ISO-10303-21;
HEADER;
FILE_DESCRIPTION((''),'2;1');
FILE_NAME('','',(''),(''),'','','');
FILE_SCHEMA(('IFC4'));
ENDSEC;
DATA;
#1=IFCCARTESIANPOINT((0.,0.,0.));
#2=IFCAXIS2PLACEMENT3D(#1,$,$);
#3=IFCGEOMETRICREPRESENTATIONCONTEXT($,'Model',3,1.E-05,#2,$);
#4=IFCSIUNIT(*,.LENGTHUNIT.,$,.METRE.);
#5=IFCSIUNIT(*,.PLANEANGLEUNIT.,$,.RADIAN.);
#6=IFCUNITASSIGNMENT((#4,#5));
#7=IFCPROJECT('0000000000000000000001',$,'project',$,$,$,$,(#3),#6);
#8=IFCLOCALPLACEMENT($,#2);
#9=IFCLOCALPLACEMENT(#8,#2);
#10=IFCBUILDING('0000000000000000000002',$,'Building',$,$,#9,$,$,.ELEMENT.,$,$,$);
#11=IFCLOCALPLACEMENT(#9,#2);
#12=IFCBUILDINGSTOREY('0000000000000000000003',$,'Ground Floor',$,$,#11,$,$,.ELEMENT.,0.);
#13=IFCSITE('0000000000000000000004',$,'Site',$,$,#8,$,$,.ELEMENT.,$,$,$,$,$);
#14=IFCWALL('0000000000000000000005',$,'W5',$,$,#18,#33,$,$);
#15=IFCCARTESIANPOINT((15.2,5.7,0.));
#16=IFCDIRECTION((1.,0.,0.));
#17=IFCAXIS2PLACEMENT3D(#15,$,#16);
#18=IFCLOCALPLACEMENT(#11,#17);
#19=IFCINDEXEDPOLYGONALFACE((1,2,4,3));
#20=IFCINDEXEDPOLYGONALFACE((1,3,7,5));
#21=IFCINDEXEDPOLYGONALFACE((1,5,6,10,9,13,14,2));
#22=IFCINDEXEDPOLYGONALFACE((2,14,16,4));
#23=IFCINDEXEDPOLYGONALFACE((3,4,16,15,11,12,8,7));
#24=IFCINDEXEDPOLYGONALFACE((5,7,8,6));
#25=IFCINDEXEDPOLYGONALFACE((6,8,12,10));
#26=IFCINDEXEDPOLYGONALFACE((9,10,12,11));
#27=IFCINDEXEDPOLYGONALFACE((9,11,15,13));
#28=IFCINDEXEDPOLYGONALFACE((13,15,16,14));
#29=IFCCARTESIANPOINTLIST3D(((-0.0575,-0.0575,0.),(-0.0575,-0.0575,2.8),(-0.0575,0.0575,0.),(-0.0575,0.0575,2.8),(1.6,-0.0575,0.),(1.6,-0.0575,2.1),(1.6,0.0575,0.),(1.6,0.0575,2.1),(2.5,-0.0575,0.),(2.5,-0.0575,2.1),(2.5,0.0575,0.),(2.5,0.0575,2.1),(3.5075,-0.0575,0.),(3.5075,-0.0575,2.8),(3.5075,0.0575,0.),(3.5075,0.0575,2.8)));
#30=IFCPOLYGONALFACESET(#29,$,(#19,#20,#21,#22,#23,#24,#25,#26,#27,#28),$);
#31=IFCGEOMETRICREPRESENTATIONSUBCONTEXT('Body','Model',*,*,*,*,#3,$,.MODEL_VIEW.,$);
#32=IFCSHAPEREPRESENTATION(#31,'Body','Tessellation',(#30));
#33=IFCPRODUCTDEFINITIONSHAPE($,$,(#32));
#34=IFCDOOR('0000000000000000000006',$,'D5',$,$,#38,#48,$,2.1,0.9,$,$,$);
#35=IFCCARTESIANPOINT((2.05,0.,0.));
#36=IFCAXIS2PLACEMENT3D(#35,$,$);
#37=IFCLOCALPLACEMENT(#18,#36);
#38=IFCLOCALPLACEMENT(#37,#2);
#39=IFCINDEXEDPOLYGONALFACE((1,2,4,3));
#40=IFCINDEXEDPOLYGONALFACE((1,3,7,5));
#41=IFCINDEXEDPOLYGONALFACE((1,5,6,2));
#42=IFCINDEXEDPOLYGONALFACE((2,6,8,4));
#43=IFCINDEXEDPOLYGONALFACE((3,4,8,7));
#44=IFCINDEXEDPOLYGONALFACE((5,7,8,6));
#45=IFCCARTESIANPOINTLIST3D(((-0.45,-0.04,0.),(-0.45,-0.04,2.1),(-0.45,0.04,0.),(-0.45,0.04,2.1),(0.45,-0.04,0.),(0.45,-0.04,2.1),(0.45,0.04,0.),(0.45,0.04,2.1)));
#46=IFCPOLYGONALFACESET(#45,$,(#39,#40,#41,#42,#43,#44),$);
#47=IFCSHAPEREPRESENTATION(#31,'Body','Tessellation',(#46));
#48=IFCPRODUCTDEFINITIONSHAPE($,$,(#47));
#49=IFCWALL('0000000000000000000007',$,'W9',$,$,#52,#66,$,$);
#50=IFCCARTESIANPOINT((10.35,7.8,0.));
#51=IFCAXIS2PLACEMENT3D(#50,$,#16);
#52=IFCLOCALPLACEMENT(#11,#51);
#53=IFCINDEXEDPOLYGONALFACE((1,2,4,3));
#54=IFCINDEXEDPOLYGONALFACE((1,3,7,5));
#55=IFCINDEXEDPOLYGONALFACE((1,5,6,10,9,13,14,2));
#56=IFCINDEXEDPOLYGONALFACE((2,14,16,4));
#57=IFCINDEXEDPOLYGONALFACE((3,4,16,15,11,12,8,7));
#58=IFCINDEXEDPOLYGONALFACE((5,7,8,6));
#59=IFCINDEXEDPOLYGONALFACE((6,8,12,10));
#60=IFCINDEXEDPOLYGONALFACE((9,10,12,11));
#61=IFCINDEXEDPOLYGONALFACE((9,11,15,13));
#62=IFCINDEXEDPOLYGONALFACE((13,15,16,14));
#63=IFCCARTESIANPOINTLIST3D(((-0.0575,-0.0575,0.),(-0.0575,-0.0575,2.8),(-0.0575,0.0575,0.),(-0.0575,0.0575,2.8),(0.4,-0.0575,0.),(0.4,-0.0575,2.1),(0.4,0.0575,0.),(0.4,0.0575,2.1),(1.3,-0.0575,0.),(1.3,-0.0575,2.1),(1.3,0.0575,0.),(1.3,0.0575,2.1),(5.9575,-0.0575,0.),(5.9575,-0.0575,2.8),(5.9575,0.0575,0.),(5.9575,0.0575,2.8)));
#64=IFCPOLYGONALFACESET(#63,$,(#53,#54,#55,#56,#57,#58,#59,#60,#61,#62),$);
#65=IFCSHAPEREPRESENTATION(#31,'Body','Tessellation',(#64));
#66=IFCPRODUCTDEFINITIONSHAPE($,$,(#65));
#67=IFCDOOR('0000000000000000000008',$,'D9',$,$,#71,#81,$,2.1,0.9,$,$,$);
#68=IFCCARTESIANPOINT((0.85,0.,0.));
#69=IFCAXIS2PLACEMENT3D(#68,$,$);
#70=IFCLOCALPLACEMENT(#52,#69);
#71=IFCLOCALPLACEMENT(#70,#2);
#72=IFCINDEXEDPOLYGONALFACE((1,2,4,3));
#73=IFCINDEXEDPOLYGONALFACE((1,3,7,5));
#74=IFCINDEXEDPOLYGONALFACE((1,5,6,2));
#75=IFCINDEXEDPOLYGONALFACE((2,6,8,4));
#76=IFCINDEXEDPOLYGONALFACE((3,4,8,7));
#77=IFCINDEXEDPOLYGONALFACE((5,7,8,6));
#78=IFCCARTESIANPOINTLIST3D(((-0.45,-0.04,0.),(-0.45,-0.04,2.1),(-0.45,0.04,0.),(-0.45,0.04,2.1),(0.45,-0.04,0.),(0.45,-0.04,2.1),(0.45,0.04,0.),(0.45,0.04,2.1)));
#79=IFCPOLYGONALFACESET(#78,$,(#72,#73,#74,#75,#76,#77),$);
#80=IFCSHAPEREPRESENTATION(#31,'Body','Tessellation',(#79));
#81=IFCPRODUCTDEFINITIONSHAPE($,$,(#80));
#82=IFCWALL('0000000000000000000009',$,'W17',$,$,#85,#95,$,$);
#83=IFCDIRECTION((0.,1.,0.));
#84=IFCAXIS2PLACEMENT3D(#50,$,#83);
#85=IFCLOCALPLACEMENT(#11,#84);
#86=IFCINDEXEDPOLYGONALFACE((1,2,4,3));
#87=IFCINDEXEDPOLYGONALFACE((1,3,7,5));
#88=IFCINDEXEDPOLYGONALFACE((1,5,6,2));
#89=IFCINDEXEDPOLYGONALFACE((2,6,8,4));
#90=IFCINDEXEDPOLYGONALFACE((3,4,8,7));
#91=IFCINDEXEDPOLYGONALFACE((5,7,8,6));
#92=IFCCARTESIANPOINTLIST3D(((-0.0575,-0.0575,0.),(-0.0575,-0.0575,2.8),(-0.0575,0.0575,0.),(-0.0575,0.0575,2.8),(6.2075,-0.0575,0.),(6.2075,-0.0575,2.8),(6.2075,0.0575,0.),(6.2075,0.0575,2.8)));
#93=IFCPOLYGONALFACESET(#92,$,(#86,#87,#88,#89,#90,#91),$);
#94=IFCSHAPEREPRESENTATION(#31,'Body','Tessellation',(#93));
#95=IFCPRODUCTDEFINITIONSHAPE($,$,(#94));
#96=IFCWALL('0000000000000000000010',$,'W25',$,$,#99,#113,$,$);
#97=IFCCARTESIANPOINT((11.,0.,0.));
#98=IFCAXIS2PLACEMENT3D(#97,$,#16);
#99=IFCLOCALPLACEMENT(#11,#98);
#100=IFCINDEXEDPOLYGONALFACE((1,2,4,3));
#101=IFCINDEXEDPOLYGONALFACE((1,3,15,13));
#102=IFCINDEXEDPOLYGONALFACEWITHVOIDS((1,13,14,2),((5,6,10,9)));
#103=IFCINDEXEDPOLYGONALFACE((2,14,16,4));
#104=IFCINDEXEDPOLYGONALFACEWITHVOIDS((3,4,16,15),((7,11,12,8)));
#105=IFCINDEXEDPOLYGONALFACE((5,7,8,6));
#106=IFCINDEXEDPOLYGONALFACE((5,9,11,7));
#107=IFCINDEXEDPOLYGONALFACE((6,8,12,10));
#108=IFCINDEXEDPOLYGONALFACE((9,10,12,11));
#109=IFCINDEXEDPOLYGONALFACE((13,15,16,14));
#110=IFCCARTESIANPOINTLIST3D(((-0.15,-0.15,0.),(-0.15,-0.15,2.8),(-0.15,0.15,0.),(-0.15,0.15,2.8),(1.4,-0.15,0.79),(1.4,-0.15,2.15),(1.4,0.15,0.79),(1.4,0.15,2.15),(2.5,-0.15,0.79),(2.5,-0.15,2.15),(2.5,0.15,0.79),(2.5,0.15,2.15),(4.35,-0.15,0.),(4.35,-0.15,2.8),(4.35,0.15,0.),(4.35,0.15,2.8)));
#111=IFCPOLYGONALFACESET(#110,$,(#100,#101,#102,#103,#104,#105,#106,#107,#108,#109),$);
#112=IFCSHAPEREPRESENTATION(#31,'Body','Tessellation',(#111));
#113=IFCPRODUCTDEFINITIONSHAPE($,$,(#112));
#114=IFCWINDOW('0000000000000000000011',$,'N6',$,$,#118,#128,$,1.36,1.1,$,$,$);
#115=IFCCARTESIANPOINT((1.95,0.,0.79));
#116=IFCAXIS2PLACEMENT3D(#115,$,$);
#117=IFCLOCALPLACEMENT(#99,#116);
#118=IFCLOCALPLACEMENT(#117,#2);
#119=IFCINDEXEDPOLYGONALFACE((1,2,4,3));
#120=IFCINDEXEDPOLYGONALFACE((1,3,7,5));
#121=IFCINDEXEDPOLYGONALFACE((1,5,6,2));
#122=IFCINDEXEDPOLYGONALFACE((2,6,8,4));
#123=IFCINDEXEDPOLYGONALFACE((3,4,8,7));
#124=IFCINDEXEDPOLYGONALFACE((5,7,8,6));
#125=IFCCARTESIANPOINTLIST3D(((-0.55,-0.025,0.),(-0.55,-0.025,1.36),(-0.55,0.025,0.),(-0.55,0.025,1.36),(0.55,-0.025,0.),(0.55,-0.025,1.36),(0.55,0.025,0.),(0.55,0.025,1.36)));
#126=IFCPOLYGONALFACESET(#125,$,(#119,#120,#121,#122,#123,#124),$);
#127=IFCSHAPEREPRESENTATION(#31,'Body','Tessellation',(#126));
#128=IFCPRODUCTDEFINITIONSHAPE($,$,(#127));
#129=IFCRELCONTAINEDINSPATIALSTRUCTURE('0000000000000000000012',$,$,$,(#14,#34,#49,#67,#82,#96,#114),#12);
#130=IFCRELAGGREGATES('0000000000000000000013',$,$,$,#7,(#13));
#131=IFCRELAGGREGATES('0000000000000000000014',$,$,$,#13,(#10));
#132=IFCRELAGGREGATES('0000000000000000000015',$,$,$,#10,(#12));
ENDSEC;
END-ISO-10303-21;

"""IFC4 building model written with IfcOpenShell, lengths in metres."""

from ifc_helpers import new_model, si_unit, frame, frame_2d, origin, origin_2d, place, context, subcontext, project, spatial, rectangle, extrude, element, fill, save


model = new_model("IFC4")

# Units and contexts
model_context = context("Model", 3, precision=1e-05, world=origin())
body_context = subcontext(model_context, "Body", "Model", "MODEL_VIEW")
ifc_project = project(units=[si_unit("LENGTHUNIT", "METRE"), si_unit("PLANEANGLEUNIT", "RADIAN")], contexts=[model_context])

# Site, building, storey
site_placement = place(None, origin())
site = spatial("IfcSite", under=ifc_project, at=site_placement, Name="Site", CompositionType="ELEMENT")
building_placement = place(site_placement, origin())
building = spatial("IfcBuilding", under=site, at=building_placement, Name="Building", CompositionType="ELEMENT")
storey_placement = place(building_placement, origin())
storey = spatial("IfcBuildingStorey", under=building, at=storey_placement, Name="Ground Floor", CompositionType="ELEMENT", Elevation=0.0)

# Walls, openings, doors
wall_1_placement = place(storey_placement, frame((15.2, 5.7, 0.0), x_axis=(1.0, 0.0, 0.0)))
wall_1 = element("IfcWall", 1, at=wall_1_placement, inside=storey, Name="W5", context=body_context, shape_type="SweptSolid", body=[
    extrude(rectangle(XDim=3.565, YDim=0.115, at=frame_2d((1.725, 0.0))), origin(), (0.0, 0.0, 1.0), 2.8),
])
opening_1_placement = place(wall_1_placement, frame((2.05, 0.0, 0.0)))
opening_1 = element("IfcOpeningElement", 2, at=opening_1_placement, cuts=wall_1, context=body_context, shape_type="SweptSolid", body=[
    extrude(rectangle(XDim=0.9, YDim=0.215, at=origin_2d()), origin(), (0.0, 0.0, 1.0), 2.1),
])
door_1_placement = place(opening_1_placement, origin())
door_1 = element("IfcDoor", 3, at=door_1_placement, inside=storey, Name="D5", OverallHeight=2.1, OverallWidth=0.9, context=body_context, shape_type="SweptSolid", body=[
    extrude(rectangle(XDim=0.9, YDim=0.08, at=origin_2d()), origin(), (0.0, 0.0, 1.0), 2.1),
])
fill(opening_1, door_1)
wall_2_placement = place(storey_placement, frame((10.35, 7.8, 0.0), x_axis=(1.0, 0.0, 0.0)))
wall_2 = element("IfcWall", 4, at=wall_2_placement, inside=storey, Name="W9", context=body_context, shape_type="SweptSolid", body=[
    extrude(rectangle(XDim=6.015, YDim=0.115, at=frame_2d((2.95, 0.0))), origin(), (0.0, 0.0, 1.0), 2.8),
])
opening_2_placement = place(wall_2_placement, frame((0.85, 0.0, 0.0)))
opening_2 = element("IfcOpeningElement", 5, at=opening_2_placement, cuts=wall_2, context=body_context, shape_type="SweptSolid", body=[
    extrude(rectangle(XDim=0.9, YDim=0.215, at=origin_2d()), origin(), (0.0, 0.0, 1.0), 2.1),
])
door_2_placement = place(opening_2_placement, origin())
door_2 = element("IfcDoor", 6, at=door_2_placement, inside=storey, Name="D9", OverallHeight=2.1, OverallWidth=0.9, context=body_context, shape_type="SweptSolid", body=[
    extrude(rectangle(XDim=0.9, YDim=0.08, at=origin_2d()), origin(), (0.0, 0.0, 1.0), 2.1),
])
fill(opening_2, door_2)

# Wall
wall_3_placement = place(storey_placement, frame((10.35, 7.8, 0.0), x_axis=(0.0, 1.0, 0.0)))
element("IfcWall", 7, at=wall_3_placement, inside=storey, Name="W17", context=body_context, shape_type="SweptSolid", body=[
    extrude(rectangle(XDim=6.265, YDim=0.115, at=frame_2d((3.075, 0.0))), origin(), (0.0, 0.0, 1.0), 2.8),
])

# Wall, opening, window
wall_4_placement = place(storey_placement, frame((11.0, 0.0, 0.0), x_axis=(1.0, 0.0, 0.0)))
wall_4 = element("IfcWall", 8, at=wall_4_placement, inside=storey, Name="W25", context=body_context, shape_type="SweptSolid", body=[
    extrude(rectangle(XDim=4.5, YDim=0.3, at=frame_2d((2.1, 0.0))), origin(), (0.0, 0.0, 1.0), 2.8),
])
opening_3_placement = place(wall_4_placement, frame((1.95, 0.0, 0.79)))
opening_3 = element("IfcOpeningElement", 9, at=opening_3_placement, cuts=wall_4, context=body_context, shape_type="SweptSolid", body=[
    extrude(rectangle(XDim=1.1, YDim=0.4, at=origin_2d()), origin(), (0.0, 0.0, 1.0), 1.36),
])
window_1_placement = place(opening_3_placement, origin())
window_1 = element("IfcWindow", 10, at=window_1_placement, inside=storey, Name="N6", OverallHeight=1.36, OverallWidth=1.1, context=body_context, shape_type="SweptSolid", body=[
    extrude(rectangle(XDim=1.1, YDim=0.05, at=origin_2d()), origin(), (0.0, 0.0, 1.0), 1.36),
])
fill(opening_3, window_1)

save(model, "model.ifc")
